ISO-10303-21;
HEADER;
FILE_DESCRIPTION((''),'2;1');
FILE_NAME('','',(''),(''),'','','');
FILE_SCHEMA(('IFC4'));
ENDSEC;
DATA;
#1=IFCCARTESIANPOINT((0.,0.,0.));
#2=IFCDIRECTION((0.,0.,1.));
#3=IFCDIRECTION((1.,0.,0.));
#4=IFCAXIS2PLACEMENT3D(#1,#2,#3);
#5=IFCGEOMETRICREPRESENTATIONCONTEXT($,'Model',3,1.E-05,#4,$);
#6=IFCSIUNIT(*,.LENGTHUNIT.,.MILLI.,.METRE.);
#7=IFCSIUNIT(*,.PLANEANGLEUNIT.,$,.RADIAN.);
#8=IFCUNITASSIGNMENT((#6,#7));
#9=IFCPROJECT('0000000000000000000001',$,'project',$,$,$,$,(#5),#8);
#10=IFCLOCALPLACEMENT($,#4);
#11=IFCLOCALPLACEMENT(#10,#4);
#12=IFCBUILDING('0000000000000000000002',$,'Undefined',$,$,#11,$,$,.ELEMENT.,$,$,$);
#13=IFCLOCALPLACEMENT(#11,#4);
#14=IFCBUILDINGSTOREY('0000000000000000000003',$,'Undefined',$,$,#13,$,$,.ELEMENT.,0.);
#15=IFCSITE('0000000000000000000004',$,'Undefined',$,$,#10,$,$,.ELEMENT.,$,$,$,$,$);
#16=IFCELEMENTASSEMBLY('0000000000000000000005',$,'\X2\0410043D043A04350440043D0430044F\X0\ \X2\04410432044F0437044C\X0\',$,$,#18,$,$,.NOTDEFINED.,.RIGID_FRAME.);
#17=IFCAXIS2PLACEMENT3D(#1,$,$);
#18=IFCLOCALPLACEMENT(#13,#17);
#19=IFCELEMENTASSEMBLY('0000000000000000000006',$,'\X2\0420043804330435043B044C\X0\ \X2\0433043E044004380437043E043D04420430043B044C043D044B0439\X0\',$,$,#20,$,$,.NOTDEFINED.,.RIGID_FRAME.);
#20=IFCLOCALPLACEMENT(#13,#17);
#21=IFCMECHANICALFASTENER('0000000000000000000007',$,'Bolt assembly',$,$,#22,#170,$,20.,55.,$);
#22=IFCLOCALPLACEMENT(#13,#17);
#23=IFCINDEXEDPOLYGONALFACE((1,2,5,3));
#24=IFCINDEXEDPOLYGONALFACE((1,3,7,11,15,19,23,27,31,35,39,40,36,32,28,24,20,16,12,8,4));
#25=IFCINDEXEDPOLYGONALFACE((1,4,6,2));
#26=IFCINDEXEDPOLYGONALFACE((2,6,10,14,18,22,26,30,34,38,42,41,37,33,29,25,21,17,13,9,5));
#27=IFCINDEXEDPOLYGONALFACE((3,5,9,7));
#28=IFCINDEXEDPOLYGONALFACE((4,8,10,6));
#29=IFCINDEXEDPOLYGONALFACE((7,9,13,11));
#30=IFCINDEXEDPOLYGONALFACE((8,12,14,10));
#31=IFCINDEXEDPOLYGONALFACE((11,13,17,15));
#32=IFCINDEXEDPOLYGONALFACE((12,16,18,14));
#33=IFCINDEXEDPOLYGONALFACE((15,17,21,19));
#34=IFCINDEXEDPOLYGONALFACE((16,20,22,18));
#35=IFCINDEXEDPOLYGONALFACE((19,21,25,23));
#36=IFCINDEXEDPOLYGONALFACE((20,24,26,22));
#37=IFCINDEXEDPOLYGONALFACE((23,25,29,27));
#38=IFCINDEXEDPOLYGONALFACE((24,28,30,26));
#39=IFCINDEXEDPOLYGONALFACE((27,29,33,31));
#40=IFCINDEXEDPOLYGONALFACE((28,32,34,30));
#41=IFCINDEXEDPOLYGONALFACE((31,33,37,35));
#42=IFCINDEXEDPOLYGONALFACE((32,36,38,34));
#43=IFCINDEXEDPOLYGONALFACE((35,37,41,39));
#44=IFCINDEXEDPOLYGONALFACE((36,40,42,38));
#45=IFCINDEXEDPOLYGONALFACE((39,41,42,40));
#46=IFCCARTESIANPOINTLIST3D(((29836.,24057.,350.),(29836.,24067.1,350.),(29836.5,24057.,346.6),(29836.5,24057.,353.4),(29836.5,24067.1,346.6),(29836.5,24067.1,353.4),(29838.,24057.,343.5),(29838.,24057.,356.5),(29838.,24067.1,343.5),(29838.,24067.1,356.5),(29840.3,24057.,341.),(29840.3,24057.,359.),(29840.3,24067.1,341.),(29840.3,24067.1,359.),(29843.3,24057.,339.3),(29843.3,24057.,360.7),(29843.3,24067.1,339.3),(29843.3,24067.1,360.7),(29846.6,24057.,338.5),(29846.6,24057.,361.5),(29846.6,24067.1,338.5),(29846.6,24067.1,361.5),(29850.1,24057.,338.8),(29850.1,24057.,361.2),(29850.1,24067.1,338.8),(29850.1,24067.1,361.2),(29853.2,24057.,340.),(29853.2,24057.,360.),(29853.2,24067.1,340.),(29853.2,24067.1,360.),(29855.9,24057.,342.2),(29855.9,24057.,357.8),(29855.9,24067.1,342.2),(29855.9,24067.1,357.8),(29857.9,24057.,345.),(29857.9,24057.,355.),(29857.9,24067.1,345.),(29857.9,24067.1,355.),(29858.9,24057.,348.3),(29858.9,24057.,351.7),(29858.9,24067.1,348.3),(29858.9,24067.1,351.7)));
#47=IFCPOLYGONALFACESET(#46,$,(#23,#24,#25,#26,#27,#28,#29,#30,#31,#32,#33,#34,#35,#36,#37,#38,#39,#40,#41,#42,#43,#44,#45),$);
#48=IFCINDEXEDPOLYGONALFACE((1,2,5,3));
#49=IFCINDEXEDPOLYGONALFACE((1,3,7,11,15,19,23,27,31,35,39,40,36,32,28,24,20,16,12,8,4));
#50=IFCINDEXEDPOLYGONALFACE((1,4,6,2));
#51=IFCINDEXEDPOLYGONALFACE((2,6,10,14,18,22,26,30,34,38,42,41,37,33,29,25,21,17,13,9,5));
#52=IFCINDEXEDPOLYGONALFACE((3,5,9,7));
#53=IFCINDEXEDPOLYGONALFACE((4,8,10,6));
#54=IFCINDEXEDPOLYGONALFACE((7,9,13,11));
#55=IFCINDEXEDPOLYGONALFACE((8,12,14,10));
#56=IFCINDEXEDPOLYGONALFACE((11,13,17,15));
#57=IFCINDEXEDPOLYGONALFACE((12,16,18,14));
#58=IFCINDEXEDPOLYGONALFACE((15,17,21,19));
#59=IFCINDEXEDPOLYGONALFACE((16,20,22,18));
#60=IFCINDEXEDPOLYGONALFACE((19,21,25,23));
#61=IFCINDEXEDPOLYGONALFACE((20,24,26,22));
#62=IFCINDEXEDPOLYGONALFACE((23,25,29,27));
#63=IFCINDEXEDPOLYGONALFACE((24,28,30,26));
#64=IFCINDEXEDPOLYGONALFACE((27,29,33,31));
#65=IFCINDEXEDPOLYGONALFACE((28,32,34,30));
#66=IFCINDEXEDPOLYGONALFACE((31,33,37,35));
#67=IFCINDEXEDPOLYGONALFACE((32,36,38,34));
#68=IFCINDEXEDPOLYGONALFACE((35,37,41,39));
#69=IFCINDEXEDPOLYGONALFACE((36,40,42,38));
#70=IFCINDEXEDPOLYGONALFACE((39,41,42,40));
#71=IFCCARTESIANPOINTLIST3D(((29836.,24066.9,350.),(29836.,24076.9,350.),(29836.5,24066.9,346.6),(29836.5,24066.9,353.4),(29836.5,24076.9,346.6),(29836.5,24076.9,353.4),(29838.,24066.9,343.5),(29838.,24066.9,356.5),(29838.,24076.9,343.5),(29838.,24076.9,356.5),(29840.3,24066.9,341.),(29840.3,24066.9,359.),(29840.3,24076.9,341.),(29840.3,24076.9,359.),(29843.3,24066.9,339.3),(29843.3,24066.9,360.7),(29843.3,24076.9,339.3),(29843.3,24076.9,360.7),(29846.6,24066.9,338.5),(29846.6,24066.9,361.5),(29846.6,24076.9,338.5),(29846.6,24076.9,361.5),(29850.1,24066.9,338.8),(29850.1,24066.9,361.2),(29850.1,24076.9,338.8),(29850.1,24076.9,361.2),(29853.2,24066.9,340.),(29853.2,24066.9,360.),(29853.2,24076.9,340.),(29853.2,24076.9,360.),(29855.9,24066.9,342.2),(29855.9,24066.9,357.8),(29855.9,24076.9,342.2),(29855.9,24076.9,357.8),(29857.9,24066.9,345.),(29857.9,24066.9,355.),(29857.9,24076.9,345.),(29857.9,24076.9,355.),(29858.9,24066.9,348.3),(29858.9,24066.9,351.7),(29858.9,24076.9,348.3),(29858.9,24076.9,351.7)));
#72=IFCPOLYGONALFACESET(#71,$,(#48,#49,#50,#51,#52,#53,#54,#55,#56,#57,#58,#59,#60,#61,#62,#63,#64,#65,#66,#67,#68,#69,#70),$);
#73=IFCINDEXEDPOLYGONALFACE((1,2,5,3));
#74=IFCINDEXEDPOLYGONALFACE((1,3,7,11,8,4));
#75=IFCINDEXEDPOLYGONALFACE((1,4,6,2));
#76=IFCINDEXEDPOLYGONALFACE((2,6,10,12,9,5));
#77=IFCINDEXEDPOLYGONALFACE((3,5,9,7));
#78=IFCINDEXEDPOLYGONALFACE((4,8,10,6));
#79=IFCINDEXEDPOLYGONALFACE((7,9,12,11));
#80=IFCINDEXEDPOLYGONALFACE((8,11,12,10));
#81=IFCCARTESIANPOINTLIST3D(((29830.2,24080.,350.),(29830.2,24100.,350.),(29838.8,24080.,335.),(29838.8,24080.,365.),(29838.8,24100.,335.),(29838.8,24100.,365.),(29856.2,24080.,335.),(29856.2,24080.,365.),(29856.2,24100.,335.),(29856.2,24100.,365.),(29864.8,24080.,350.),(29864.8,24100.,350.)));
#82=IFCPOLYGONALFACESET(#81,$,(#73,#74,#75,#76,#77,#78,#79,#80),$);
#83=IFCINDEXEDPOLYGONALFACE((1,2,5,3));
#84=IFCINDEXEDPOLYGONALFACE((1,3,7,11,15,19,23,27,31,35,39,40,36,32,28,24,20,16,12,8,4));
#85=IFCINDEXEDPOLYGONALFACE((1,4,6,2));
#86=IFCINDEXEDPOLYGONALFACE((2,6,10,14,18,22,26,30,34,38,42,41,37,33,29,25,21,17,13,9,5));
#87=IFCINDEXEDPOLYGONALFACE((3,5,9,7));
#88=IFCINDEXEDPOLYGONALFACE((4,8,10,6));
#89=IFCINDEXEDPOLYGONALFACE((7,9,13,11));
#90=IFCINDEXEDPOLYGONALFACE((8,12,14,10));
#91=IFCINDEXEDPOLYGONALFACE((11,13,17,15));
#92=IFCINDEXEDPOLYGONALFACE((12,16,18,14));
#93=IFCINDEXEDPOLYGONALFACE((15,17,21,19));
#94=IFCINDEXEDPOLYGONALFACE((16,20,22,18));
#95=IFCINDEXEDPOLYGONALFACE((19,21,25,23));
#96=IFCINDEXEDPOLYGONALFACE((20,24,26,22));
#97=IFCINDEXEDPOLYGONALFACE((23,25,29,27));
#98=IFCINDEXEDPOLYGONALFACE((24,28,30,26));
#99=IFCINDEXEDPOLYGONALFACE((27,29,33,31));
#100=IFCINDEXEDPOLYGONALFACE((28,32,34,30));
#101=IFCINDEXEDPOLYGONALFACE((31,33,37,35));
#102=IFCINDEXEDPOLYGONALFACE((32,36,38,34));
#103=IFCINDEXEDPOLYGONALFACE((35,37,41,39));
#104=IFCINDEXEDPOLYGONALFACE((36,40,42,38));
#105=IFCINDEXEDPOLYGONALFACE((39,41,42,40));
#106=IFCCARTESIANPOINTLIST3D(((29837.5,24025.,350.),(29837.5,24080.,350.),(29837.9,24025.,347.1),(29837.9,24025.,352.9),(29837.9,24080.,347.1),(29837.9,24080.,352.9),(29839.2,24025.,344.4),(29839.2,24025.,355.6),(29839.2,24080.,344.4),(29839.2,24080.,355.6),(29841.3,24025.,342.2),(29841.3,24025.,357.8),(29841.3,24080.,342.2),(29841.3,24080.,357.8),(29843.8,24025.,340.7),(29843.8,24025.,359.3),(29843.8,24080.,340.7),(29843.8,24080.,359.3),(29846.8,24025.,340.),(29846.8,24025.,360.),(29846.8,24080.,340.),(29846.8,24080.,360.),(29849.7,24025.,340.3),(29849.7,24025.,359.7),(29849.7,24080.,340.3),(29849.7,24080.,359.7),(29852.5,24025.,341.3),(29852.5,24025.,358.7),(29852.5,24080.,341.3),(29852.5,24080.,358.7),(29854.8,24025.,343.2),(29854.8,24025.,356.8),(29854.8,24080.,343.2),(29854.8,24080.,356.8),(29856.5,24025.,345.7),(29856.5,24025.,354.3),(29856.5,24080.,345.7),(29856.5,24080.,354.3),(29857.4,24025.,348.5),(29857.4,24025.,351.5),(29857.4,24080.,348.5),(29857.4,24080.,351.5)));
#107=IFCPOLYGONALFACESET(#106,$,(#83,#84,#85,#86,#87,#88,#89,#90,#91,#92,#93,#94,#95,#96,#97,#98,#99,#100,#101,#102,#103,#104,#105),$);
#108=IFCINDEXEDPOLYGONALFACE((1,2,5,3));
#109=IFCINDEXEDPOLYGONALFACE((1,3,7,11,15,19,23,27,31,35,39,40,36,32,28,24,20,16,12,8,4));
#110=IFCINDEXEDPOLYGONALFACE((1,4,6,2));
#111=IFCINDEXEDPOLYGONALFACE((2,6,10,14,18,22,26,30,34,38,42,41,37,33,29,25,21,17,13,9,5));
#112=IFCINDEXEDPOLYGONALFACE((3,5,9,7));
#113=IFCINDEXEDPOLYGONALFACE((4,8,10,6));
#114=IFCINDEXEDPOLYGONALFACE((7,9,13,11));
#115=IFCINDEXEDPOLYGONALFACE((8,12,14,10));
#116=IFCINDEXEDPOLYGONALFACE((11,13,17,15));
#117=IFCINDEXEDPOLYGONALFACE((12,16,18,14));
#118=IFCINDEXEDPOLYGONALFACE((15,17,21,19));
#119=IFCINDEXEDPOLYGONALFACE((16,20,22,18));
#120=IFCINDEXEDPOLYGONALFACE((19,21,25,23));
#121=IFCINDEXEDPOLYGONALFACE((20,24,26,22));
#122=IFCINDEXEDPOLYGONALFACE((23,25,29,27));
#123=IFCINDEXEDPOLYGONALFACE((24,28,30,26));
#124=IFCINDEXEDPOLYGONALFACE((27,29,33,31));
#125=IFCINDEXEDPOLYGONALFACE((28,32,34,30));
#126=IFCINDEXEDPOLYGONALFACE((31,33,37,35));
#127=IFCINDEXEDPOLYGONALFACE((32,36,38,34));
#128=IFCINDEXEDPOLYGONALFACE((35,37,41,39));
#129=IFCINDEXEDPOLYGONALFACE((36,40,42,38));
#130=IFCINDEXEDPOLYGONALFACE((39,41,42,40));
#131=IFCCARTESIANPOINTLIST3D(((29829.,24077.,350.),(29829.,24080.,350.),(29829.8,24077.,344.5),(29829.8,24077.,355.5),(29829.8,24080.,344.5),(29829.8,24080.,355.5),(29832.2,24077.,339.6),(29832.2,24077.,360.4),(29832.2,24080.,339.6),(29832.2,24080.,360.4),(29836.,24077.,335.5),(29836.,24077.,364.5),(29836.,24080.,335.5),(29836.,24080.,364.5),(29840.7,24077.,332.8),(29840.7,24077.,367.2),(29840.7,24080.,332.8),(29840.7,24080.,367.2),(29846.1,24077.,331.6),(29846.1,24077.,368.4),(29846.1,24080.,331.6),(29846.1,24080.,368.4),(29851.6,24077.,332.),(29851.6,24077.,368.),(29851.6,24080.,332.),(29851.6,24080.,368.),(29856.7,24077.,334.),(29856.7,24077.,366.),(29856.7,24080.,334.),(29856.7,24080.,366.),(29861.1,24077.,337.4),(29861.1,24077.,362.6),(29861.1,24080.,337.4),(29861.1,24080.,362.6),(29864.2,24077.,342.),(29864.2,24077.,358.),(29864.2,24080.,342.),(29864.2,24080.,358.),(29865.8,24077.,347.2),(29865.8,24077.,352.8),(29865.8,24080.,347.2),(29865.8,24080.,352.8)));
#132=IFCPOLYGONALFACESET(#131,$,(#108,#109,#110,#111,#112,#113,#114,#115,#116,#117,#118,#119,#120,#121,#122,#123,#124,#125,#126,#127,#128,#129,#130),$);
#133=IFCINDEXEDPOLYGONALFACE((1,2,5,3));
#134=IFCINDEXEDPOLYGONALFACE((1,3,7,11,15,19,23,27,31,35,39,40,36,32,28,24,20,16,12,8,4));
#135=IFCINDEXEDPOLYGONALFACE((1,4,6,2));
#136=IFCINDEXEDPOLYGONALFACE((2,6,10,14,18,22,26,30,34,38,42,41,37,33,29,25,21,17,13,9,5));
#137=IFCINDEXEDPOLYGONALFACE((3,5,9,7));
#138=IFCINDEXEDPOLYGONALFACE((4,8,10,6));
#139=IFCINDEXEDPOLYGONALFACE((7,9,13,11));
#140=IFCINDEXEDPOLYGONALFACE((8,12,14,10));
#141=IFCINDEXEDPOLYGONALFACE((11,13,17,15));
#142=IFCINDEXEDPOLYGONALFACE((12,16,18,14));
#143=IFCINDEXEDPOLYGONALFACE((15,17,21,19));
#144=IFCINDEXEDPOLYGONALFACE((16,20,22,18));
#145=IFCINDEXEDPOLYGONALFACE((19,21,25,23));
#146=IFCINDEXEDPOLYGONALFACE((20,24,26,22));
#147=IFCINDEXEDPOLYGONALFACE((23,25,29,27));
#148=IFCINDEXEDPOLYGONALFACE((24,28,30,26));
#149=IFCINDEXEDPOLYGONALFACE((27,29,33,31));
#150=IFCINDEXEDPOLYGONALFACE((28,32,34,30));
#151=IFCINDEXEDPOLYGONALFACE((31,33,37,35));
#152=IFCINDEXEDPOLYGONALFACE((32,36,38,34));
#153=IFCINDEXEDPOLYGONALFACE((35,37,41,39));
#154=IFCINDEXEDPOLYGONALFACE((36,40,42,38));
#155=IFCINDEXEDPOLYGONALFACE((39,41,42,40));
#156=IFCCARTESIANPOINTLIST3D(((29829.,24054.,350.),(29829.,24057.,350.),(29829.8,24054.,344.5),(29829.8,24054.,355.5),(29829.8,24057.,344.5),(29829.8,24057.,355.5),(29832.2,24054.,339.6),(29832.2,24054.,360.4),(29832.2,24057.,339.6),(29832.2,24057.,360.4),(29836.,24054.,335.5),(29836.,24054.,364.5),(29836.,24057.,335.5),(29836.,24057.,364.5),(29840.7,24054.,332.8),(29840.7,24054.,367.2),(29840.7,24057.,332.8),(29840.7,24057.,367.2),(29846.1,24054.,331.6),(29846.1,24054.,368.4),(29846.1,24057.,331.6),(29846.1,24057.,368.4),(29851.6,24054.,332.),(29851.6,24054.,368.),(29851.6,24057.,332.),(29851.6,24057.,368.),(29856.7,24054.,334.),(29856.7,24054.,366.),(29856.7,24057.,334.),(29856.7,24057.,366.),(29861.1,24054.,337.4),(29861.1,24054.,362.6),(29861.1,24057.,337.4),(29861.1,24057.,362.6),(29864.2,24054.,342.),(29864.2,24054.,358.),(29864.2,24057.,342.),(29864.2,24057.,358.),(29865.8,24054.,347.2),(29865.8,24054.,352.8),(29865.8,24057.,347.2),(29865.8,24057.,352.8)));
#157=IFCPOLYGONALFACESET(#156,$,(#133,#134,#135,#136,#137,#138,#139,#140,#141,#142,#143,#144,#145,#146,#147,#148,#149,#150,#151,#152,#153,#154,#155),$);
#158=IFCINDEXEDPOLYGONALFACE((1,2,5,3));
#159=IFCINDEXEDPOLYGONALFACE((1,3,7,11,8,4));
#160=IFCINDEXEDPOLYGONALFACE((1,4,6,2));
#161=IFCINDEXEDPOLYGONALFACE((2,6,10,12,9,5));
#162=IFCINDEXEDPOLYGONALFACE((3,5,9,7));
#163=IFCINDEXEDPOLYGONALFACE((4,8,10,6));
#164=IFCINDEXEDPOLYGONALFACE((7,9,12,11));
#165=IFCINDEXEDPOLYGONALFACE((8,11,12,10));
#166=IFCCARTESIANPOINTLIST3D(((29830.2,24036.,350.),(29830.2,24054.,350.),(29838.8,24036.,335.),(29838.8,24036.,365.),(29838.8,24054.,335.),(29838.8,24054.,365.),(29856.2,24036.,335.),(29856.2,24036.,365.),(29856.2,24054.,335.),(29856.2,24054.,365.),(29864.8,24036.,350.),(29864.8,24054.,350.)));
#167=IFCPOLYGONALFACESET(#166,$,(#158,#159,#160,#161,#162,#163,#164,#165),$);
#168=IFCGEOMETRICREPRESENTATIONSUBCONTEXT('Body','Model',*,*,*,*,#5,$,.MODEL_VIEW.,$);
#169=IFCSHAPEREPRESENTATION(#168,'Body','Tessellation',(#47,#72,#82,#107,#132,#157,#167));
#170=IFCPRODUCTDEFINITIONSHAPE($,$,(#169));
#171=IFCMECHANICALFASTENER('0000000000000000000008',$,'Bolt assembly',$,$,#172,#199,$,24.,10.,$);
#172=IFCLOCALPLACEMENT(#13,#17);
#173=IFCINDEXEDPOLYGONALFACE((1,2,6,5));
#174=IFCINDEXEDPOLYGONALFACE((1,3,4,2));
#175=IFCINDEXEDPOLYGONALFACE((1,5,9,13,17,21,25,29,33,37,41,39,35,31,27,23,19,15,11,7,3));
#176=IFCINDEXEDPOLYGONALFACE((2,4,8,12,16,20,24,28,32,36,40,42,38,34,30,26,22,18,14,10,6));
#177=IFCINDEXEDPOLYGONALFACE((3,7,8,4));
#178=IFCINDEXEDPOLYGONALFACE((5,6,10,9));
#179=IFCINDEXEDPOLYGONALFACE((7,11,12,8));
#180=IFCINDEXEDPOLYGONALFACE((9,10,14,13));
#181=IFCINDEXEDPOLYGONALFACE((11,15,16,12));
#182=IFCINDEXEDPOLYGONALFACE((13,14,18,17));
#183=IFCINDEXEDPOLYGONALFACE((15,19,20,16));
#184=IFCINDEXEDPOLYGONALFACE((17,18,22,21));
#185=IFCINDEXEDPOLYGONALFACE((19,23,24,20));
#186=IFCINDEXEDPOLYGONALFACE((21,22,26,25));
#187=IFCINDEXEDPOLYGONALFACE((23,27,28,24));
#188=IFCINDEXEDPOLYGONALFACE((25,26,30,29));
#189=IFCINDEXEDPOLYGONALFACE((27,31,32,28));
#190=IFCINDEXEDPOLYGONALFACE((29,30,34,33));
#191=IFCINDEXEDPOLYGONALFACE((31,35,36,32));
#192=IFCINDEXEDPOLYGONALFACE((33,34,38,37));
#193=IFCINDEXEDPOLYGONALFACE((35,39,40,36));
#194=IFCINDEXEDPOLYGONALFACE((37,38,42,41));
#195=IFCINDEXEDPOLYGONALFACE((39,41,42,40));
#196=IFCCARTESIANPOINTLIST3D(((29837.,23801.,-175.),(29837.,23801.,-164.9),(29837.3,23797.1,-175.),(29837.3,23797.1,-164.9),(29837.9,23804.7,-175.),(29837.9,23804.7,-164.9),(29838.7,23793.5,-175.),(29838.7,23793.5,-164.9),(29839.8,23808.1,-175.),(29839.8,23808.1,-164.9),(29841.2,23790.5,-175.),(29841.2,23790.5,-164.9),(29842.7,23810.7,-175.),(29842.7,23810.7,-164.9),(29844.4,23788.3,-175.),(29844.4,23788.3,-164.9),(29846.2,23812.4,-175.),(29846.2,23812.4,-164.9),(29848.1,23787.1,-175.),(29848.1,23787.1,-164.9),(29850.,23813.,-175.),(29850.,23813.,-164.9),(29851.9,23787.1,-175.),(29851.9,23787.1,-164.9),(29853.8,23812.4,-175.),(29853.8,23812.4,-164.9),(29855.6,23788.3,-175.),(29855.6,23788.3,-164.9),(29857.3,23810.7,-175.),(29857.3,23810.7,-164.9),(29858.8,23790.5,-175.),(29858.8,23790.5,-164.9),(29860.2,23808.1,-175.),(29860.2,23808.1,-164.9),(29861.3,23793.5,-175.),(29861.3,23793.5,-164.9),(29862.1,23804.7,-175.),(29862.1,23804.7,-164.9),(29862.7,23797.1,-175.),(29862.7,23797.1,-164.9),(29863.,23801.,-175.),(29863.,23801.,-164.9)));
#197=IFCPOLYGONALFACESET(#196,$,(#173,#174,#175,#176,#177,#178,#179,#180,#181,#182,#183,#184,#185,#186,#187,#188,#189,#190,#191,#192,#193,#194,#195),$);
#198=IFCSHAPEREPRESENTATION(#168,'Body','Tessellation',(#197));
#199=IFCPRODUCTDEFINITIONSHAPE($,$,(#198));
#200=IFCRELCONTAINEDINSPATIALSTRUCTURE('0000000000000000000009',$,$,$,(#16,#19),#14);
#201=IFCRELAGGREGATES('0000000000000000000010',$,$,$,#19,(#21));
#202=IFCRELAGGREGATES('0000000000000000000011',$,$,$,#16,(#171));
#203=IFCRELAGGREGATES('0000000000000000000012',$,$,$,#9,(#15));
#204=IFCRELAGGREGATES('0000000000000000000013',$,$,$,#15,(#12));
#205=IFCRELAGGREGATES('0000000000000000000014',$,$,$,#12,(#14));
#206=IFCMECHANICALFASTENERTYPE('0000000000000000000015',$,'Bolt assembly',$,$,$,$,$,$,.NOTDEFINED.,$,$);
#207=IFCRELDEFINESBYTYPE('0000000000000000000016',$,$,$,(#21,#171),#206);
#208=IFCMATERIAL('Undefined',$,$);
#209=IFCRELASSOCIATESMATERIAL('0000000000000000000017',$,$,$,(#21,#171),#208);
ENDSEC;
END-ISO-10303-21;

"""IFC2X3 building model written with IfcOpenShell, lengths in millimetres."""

from ifc_helpers import new_model, si_unit, frame, origin_with_axes, origin_2d_with_axis, place, context, subcontext, project, spatial, polyline, circle, outline, extrude, source, transform, mapped, material, type_object, element, aggregate, save


model = new_model("IFC2X3")

# Units and contexts
model_context = context("Model", 3, precision=1e-05, world=origin_with_axes())
body_context = subcontext(model_context, "Body", "Model", "MODEL_VIEW")
ifc_project = project(units=[si_unit("LENGTHUNIT", "METRE", prefix="MILLI"), si_unit("PLANEANGLEUNIT", "RADIAN")], contexts=[model_context])

# Site, building, storey
site_placement = place(None, origin_with_axes())
site = spatial("IfcSite", under=ifc_project, at=site_placement, Name="Undefined", CompositionType="ELEMENT")
building_placement = place(site_placement, origin_with_axes())
building = spatial("IfcBuilding", under=site, at=building_placement, Name="Undefined", CompositionType="ELEMENT")
storey_placement = place(building_placement, origin_with_axes())
storey = spatial("IfcBuildingStorey", under=building, at=storey_placement, Name="Undefined", CompositionType="ELEMENT", Elevation=0.0)

# Element assembly
assembly_1_placement = place(storey_placement, origin_with_axes())
assembly_1 = element("IfcElementAssembly", 1, at=assembly_1_placement, inside=storey, Name="Анкерная связь", AssemblyPlace="NOTDEFINED", PredefinedType="RIGID_FRAME")

# Element assembly
assembly_2_placement = place(storey_placement, origin_with_axes())
assembly_2 = element("IfcElementAssembly", 2, at=assembly_2_placement, inside=storey, Name="Ригель горизонтальный", AssemblyPlace="NOTDEFINED", PredefinedType="RIGID_FRAME")

# Mechanical fasteners
ifc_material_1 = material(Name="Undefined")
mechanical_fastener_type = type_object("IfcMechanicalFastenerType", Name="Bolt assembly")
shared_shape_1 = source(origin_with_axes(), body_context, "Body", "SweptSolid", [
    extrude(circle(Radius=11.5, at=origin_2d_with_axis()), frame((0.0, -0.1, 0.0), z_axis=(0.0, 1.0, 0.0), x_axis=(1.0, 0.0, 0.0)), (0.0, 0.0, 1.0), 10.1),
    extrude(circle(Radius=11.5, at=origin_2d_with_axis()), frame((0.0, -9.9, 0.0), z_axis=(0.0, 1.0, 0.0), x_axis=(1.0, 0.0, 0.0)), (0.0, 0.0, 1.0), 10.0),
    extrude(outline(polyline([(17.3, 0.0), (8.7, 15.0), (-8.7, 15.0), (-17.3, 0.0), (-8.7, -15.0), (8.7, -15.0), (17.3, 0.0)])), frame((0.0, -33.0, 0.0), z_axis=(0.0, 1.0, 0.0), x_axis=(1.0, 0.0, 0.0)), (0.0, 0.0, 1.0), 20.0),
    extrude(circle(Radius=10.0, at=origin_2d_with_axis()), frame((0.0, -13.0, 0.0), z_axis=(0.0, 1.0, 0.0), x_axis=(1.0, 0.0, 0.0)), (0.0, 0.0, 1.0), 55.0),
    extrude(circle(Radius=18.5, at=origin_2d_with_axis()), frame((0.0, -13.0, 0.0), z_axis=(0.0, 1.0, 0.0), x_axis=(1.0, 0.0, 0.0)), (0.0, 0.0, 1.0), 3.0),
    extrude(circle(Radius=18.5, at=origin_2d_with_axis()), frame((0.0, 10.0, 0.0), z_axis=(0.0, 1.0, 0.0), x_axis=(1.0, 0.0, 0.0)), (0.0, 0.0, 1.0), 3.0),
    extrude(outline(polyline([(17.3, 0.0), (8.7, 15.0), (-8.7, 15.0), (-17.3, 0.0), (-8.7, -15.0), (8.7, -15.0), (17.3, 0.0)])), frame((0.0, 13.0, 0.0), z_axis=(0.0, 1.0, 0.0), x_axis=(1.0, 0.0, 0.0)), (0.0, 0.0, 1.0), 18.0),
])
mechanical_fastener_1_placement = place(assembly_2_placement, frame((29847.5, 24067.0, 350.0), z_axis=(0.0, 0.0, 1.0), x_axis=(-1.0, 0.0, 0.0)))
mechanical_fastener_1 = element("IfcMechanicalFastener", 3, at=mechanical_fastener_1_placement, type_object=mechanical_fastener_type, material=ifc_material_1, Name="Bolt assembly", NominalDiameter=20.0, NominalLength=55.0, context=body_context, shape_type="MappedRepresentation", body=[
    mapped(shared_shape_1, transform((0.0, 0.0, 0.0))),
])
aggregate(assembly_2, [mechanical_fastener_1])
shared_shape_2 = source(origin_with_axes(), body_context, "Body", "SweptSolid", [
    extrude(circle(Radius=13.0, at=origin_2d_with_axis()), frame((0.0, 0.0, 0.0), z_axis=(0.0, 1.0, 0.0), x_axis=(1.0, 0.0, 0.0)), (0.0, 0.0, 1.0), 10.1),
])
mechanical_fastener_2_placement = place(assembly_1_placement, frame((29850.0, 23800.0, -175.0), z_axis=(1.0, 0.0, 0.0), x_axis=(0.0, 1.0, 0.0)))
mechanical_fastener_2 = element("IfcMechanicalFastener", 4, at=mechanical_fastener_2_placement, type_object=mechanical_fastener_type, material=ifc_material_1, Name="Bolt assembly", NominalDiameter=24.0, NominalLength=10.0, context=body_context, shape_type="MappedRepresentation", body=[
    mapped(shared_shape_2, transform((0.0, 0.0, 0.0))),
])
aggregate(assembly_1, [mechanical_fastener_2])

save(model, "model.ifc")
